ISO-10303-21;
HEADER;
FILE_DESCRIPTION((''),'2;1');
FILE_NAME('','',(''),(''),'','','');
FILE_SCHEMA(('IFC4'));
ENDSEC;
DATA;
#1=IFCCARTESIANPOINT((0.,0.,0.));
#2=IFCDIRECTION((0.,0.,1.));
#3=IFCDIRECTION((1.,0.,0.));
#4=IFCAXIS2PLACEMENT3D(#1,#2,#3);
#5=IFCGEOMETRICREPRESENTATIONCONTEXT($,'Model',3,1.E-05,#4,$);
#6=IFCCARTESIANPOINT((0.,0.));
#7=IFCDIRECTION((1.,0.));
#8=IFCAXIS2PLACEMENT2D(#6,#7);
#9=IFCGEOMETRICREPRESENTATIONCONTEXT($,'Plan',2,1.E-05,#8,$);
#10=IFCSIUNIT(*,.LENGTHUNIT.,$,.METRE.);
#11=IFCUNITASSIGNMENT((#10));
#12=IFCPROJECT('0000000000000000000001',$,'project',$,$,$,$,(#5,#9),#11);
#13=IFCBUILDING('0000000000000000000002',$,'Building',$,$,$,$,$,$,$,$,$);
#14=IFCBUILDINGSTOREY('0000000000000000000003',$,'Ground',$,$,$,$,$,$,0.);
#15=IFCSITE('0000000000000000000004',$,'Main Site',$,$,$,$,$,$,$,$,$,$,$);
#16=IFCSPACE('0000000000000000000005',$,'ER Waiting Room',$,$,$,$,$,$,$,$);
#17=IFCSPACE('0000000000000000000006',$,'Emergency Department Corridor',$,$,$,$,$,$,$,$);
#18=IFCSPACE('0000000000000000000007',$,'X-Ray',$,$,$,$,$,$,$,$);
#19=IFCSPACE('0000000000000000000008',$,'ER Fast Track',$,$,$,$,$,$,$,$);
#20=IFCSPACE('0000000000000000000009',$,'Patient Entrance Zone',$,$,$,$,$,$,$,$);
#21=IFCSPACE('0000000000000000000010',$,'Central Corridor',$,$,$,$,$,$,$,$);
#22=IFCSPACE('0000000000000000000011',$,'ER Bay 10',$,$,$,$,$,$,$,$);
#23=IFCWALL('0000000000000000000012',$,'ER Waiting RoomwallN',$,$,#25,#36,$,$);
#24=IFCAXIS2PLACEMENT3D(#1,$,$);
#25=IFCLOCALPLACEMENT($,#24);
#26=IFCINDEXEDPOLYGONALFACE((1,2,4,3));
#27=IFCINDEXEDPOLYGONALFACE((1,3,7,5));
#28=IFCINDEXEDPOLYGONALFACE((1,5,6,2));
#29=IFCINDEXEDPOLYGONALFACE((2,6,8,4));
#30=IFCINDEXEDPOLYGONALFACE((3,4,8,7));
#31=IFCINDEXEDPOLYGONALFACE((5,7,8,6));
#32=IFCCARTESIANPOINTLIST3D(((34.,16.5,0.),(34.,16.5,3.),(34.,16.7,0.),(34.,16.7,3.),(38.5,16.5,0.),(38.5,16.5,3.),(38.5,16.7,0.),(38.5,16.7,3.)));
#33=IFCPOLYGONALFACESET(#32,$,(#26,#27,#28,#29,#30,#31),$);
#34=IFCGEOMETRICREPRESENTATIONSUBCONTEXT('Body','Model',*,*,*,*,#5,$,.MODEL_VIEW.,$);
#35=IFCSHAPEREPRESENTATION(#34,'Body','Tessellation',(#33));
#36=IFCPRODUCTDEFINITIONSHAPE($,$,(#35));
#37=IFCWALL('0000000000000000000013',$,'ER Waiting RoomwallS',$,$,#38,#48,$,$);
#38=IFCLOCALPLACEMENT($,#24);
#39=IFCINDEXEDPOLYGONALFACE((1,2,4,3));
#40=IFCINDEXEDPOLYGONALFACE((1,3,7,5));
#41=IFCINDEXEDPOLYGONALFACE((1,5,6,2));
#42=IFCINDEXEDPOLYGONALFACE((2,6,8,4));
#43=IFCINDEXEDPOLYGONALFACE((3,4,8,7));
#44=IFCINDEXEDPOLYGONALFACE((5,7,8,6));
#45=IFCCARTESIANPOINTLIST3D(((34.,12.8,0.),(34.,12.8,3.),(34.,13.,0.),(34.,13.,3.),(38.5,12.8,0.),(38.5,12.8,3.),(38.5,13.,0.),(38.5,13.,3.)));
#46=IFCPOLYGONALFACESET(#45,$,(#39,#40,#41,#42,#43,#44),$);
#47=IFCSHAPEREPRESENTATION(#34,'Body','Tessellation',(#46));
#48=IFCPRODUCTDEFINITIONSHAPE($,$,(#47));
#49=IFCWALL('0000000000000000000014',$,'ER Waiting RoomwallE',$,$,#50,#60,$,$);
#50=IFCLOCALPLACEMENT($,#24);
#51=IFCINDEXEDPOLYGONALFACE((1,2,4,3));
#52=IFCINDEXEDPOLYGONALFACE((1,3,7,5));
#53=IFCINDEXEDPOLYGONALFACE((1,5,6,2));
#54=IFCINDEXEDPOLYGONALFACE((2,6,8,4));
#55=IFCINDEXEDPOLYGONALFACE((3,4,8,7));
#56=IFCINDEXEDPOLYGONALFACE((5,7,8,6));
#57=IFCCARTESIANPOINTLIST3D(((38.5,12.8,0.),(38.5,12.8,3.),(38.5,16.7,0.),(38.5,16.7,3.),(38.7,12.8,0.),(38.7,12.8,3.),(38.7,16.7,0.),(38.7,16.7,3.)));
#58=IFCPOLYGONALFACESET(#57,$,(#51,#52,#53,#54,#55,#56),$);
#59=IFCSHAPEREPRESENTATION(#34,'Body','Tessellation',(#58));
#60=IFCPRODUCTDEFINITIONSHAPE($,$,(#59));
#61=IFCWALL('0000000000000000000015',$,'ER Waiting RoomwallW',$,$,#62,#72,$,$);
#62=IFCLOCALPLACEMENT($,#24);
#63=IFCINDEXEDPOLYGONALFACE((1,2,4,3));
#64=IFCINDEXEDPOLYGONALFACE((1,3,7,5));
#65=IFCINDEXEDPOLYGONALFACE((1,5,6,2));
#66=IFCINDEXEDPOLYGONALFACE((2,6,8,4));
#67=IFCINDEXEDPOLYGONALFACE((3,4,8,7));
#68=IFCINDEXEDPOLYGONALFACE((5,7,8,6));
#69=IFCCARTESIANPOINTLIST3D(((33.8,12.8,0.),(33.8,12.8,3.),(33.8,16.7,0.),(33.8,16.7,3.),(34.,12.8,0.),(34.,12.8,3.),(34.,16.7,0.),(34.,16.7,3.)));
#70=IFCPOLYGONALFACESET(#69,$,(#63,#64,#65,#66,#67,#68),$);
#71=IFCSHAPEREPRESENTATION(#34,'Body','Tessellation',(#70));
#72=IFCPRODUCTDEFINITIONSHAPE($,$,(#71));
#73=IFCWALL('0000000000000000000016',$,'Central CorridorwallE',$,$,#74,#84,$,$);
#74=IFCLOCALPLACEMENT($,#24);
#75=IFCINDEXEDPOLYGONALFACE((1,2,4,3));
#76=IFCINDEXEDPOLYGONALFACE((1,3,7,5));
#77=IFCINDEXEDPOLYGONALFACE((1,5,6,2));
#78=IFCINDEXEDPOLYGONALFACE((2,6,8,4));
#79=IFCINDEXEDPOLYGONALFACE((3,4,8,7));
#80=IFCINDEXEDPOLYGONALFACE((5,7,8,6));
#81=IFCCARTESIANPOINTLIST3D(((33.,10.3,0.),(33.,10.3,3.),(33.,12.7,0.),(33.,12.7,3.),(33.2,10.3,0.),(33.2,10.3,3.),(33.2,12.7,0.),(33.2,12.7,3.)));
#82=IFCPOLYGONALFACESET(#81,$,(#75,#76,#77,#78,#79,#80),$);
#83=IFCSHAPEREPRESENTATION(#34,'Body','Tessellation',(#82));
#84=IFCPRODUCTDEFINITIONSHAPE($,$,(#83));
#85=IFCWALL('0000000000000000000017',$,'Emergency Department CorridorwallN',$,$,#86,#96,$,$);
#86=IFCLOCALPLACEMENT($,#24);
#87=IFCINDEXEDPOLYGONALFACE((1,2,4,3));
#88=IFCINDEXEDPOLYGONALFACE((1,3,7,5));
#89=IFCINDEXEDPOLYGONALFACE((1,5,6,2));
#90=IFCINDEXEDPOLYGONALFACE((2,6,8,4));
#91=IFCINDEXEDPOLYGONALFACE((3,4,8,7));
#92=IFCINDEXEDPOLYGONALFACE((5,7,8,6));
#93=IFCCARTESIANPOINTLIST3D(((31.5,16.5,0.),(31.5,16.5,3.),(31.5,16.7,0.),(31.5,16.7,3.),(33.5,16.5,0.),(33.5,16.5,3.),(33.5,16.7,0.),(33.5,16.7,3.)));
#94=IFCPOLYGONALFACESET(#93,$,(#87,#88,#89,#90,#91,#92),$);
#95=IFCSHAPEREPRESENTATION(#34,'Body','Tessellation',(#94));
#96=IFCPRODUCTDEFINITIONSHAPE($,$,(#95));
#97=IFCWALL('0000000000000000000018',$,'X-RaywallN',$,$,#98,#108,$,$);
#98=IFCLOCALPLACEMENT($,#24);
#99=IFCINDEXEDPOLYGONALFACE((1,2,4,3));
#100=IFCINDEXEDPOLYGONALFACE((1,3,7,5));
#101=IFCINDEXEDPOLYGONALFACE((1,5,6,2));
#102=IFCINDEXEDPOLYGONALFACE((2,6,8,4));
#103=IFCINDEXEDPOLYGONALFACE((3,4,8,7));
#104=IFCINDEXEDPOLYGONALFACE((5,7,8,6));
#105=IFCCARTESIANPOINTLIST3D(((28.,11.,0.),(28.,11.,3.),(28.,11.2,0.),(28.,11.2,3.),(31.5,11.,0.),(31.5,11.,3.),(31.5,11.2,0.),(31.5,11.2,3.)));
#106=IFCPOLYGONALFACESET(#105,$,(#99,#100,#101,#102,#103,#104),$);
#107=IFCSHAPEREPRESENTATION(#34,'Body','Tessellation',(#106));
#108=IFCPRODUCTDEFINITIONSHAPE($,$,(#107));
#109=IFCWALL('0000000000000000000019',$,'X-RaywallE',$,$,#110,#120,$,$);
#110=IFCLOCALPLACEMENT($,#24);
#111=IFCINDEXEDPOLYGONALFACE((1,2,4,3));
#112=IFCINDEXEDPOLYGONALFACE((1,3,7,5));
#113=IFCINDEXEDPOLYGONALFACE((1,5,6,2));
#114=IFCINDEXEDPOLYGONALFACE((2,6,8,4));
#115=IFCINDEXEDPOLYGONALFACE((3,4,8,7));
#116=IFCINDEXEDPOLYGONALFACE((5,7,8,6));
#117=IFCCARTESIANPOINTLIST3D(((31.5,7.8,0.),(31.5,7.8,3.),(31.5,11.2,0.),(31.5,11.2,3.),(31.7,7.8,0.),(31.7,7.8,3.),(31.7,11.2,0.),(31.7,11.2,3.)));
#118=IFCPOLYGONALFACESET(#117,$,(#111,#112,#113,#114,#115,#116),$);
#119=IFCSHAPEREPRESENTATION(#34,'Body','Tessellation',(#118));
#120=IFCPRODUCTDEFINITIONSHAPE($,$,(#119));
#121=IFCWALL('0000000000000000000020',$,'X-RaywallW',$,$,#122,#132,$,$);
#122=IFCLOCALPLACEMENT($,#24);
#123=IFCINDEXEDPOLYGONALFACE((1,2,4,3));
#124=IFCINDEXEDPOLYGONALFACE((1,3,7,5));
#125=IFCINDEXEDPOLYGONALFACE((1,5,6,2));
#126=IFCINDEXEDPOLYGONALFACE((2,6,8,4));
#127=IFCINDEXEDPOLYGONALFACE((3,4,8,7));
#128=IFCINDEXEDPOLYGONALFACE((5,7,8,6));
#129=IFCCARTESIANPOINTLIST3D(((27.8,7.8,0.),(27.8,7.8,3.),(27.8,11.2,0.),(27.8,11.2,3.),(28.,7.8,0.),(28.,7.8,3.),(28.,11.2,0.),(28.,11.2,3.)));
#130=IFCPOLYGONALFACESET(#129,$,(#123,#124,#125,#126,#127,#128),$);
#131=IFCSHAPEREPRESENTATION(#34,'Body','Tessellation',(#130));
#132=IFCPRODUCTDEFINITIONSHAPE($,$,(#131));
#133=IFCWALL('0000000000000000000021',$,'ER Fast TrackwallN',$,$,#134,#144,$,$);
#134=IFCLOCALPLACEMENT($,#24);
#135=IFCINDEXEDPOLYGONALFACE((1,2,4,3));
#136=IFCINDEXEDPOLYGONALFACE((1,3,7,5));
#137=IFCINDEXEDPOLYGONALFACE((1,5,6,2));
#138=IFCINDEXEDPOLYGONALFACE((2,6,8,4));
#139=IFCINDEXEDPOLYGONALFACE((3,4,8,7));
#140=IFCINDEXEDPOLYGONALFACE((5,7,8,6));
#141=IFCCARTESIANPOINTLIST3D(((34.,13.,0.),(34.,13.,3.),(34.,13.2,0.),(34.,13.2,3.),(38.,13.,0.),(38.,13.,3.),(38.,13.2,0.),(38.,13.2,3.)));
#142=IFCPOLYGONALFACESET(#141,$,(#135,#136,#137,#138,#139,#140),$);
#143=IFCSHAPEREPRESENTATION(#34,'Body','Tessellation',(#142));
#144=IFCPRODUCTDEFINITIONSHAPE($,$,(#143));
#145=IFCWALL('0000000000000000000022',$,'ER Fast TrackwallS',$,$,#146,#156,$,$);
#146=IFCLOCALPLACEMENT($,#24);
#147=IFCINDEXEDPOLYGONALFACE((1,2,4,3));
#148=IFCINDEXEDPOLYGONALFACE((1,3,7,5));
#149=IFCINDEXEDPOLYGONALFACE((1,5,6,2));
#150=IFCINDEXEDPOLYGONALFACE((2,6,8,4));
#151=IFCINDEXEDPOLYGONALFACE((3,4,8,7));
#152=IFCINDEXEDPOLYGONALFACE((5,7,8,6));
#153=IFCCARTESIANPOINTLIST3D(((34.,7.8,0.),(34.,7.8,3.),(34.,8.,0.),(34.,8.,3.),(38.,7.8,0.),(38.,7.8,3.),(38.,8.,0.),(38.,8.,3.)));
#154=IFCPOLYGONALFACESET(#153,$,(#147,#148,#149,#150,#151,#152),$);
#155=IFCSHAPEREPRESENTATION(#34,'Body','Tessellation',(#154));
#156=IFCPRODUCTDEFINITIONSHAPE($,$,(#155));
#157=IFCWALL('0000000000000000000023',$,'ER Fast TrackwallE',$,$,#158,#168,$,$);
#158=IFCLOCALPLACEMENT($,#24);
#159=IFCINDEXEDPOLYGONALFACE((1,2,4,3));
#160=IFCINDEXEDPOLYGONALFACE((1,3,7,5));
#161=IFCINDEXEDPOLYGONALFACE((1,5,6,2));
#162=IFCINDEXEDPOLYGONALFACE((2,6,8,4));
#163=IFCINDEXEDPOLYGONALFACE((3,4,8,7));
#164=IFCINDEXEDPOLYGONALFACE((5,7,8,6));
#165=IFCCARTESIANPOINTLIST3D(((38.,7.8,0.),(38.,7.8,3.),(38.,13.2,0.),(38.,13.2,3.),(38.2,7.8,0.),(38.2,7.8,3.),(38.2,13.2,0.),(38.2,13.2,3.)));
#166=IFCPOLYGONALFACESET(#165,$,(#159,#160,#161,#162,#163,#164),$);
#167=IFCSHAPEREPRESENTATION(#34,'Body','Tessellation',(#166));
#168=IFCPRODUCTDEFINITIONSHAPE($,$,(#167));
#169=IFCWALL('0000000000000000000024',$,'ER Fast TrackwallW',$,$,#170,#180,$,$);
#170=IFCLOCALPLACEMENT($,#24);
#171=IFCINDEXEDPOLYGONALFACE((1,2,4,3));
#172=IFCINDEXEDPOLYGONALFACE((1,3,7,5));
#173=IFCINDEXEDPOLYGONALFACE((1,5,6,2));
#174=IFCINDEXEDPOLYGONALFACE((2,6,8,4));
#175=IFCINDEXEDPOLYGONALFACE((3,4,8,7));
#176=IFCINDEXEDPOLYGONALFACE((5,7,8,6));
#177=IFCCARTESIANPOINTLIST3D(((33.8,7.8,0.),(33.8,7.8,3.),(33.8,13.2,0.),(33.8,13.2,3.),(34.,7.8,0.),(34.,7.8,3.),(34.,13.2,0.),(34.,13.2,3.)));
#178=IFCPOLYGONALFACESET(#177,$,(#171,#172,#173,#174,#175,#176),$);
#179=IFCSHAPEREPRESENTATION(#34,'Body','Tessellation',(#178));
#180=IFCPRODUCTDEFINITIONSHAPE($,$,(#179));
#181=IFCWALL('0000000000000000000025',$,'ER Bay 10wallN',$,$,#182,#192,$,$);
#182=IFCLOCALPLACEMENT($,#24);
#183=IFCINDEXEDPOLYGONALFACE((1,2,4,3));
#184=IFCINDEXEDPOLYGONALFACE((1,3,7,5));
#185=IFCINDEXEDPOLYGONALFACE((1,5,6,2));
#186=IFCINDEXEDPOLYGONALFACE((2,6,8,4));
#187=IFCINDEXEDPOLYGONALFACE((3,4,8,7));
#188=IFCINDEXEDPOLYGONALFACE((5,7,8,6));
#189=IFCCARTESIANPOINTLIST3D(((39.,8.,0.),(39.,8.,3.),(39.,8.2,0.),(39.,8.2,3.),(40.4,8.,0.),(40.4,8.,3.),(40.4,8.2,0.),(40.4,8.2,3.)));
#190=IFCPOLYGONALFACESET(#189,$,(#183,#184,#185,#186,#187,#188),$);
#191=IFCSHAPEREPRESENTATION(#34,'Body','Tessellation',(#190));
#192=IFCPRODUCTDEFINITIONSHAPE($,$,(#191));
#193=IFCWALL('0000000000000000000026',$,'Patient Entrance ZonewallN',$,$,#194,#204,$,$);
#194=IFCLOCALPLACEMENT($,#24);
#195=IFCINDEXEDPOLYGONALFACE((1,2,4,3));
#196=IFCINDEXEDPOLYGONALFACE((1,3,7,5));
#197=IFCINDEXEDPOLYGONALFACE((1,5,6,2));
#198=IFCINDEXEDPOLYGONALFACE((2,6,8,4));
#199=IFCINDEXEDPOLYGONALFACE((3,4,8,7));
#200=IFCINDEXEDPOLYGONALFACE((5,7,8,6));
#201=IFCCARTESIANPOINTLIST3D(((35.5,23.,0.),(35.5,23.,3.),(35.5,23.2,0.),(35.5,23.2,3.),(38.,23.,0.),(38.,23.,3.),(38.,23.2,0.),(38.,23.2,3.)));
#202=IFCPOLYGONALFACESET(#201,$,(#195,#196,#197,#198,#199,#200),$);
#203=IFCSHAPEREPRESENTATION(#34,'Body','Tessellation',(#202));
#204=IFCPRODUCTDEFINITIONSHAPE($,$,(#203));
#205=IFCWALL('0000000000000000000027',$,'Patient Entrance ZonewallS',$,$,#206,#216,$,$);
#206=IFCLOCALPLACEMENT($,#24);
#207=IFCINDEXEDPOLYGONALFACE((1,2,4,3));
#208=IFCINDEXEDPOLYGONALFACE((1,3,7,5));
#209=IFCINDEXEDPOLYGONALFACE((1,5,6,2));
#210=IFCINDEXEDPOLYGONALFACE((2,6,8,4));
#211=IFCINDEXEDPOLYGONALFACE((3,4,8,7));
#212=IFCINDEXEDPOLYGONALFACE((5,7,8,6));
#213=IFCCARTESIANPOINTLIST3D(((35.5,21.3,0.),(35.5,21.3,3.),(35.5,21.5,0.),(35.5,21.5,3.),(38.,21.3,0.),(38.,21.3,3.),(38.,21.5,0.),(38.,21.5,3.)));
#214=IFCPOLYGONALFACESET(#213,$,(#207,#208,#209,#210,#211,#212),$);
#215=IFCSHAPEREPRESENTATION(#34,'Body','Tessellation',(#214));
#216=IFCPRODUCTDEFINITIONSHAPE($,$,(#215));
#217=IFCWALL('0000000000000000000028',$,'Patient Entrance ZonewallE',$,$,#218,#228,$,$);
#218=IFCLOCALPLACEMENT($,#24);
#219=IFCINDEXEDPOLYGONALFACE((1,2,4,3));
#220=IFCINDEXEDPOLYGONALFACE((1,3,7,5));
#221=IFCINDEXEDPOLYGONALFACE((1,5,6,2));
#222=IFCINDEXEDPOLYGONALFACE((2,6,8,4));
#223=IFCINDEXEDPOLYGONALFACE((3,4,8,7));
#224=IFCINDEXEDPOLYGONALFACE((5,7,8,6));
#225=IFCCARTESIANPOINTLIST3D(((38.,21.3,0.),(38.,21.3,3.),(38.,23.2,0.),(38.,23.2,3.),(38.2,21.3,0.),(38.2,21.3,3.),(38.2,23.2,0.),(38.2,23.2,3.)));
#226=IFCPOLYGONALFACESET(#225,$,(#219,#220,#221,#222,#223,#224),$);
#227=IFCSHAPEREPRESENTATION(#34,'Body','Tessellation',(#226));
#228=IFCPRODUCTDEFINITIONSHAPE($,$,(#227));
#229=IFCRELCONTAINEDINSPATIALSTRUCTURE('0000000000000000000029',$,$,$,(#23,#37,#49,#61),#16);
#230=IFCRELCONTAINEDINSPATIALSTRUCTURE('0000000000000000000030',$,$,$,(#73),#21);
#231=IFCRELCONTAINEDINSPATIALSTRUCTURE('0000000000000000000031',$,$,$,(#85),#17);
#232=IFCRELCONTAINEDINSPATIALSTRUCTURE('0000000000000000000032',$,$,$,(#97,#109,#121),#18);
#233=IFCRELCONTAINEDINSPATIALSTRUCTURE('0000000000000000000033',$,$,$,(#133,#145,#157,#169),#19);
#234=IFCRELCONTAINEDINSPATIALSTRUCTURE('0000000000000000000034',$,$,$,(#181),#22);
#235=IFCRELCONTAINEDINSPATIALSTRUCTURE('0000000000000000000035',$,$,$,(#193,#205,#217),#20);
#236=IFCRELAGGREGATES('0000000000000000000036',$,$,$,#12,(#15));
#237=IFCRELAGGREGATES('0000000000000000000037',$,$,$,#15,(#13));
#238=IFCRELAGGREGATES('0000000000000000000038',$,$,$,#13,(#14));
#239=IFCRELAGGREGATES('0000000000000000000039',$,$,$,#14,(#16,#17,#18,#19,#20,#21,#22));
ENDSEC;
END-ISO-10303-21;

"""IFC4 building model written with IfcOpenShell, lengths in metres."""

from ifc_helpers import new_model, si_unit, frame, origin_with_axes, origin_2d_with_axis, place, context, subcontext, project, spatial, indexed_curve, outline, extrude, element, save


model = new_model("IFC4")

# Units and contexts
model_context = context("Model", 3, precision=1e-05, world=origin_with_axes())
plan_context = context("Plan", 2, precision=1e-05, world=origin_2d_with_axis())
body_context = subcontext(model_context, "Body", "Model", "MODEL_VIEW")
ifc_project = project(units=[si_unit("LENGTHUNIT", "METRE")], contexts=[model_context, plan_context])

# Site, building, storey
site = spatial("IfcSite", under=ifc_project, Name="Main Site")
building = spatial("IfcBuilding", under=site, Name="Building")
storey = spatial("IfcBuildingStorey", under=building, Name="Ground", Elevation=0.0)

# Shared definitions
space_1 = spatial("IfcSpace", under=storey, Name="ER Waiting Room")

# Shared definitions
space_2 = spatial("IfcSpace", under=storey, Name="Emergency Department Corridor")

# Shared definitions
space_3 = spatial("IfcSpace", under=storey, Name="X-Ray")

# Shared definitions
space_4 = spatial("IfcSpace", under=storey, Name="ER Fast Track")

# Shared definitions
space_5 = spatial("IfcSpace", under=storey, Name="Patient Entrance Zone")

# Walls
for number, where, z_axis, x_axis, name in (
    (1, (34.0, 16.5, 0.0), (0.0, 0.0, 1.0), (1.0, 0.0, 0.0), "ER Waiting RoomwallN"),
    (2, (34.0, 12.8, 0.0), (0.0, 0.0, 1.0), (1.0, 0.0, 0.0), "ER Waiting RoomwallS"),
):
    element("IfcWall", number, at=place(None, frame(where, z_axis=z_axis, x_axis=x_axis)), inside=space_1, Name=name, context=body_context, shape_type="SweptSolid", body=[
        extrude(outline(indexed_curve([(0.0, 0.0), (0.0, 0.2), (4.5, 0.2), (4.5, 0.0), (0.0, 0.0)], self_intersect=False)), origin_with_axes(), (0.0, 0.0, 1.0), 3.0),
    ])
for number, where, z_axis, x_axis, name in (
    (3, (38.7, 12.8, 0.0), (0.0, 0.0, 1.0), (0.0, 1.0, 0.0), "ER Waiting RoomwallE"),
    (4, (34.0, 12.8, 0.0), (0.0, 0.0, 1.0), (0.0, 1.0, 0.0), "ER Waiting RoomwallW"),
):
    element("IfcWall", number, at=place(None, frame(where, z_axis=z_axis, x_axis=x_axis)), inside=space_1, Name=name, context=body_context, shape_type="SweptSolid", body=[
        extrude(outline(indexed_curve([(0.0, 0.0), (0.0, 0.2), (3.9, 0.2), (3.9, 0.0), (0.0, 0.0)], self_intersect=False)), origin_with_axes(), (0.0, 0.0, 1.0), 3.0),
    ])

# Shared definitions
space_6 = spatial("IfcSpace", under=storey, Name="Central Corridor")

# Walls
wall_1_placement = place(None, frame((33.2, 10.3, 0.0), z_axis=(0.0, 0.0, 1.0), x_axis=(0.0, 1.0, 0.0)))
element("IfcWall", 5, at=wall_1_placement, inside=space_6, Name="Central CorridorwallE", context=body_context, shape_type="SweptSolid", body=[
    extrude(outline(indexed_curve([(0.0, 0.0), (0.0, 0.2), (2.4, 0.2), (2.4, 0.0), (0.0, 0.0)], self_intersect=False)), origin_with_axes(), (0.0, 0.0, 1.0), 3.0),
])
wall_2_placement = place(None, frame((31.5, 16.5, 0.0), z_axis=(0.0, 0.0, 1.0), x_axis=(1.0, 0.0, 0.0)))
element("IfcWall", 6, at=wall_2_placement, inside=space_2, Name="Emergency Department CorridorwallN", context=body_context, shape_type="SweptSolid", body=[
    extrude(outline(indexed_curve([(0.0, 0.0), (0.0, 0.2), (2.0, 0.2), (2.0, 0.0), (0.0, 0.0)], self_intersect=False)), origin_with_axes(), (0.0, 0.0, 1.0), 3.0),
])
wall_3_placement = place(None, frame((28.0, 11.0, 0.0), z_axis=(0.0, 0.0, 1.0), x_axis=(1.0, 0.0, 0.0)))
element("IfcWall", 7, at=wall_3_placement, inside=space_3, Name="X-RaywallN", context=body_context, shape_type="SweptSolid", body=[
    extrude(outline(indexed_curve([(0.0, 0.0), (0.0, 0.2), (3.5, 0.2), (3.5, 0.0), (0.0, 0.0)], self_intersect=False)), origin_with_axes(), (0.0, 0.0, 1.0), 3.0),
])
for number, where, z_axis, x_axis, name in (
    (8, (31.7, 7.8, 0.0), (0.0, 0.0, 1.0), (0.0, 1.0, 0.0), "X-RaywallE"),
    (9, (28.0, 7.8, 0.0), (0.0, 0.0, 1.0), (0.0, 1.0, 0.0), "X-RaywallW"),
):
    element("IfcWall", number, at=place(None, frame(where, z_axis=z_axis, x_axis=x_axis)), inside=space_3, Name=name, context=body_context, shape_type="SweptSolid", body=[
        extrude(outline(indexed_curve([(0.0, 0.0), (0.0, 0.2), (3.4, 0.2), (3.4, 0.0), (0.0, 0.0)], self_intersect=False)), origin_with_axes(), (0.0, 0.0, 1.0), 3.0),
    ])
for number, where, z_axis, x_axis, name in (
    (10, (34.0, 13.0, 0.0), (0.0, 0.0, 1.0), (1.0, 0.0, 0.0), "ER Fast TrackwallN"),
    (11, (34.0, 7.8, 0.0), (0.0, 0.0, 1.0), (1.0, 0.0, 0.0), "ER Fast TrackwallS"),
):
    element("IfcWall", number, at=place(None, frame(where, z_axis=z_axis, x_axis=x_axis)), inside=space_4, Name=name, context=body_context, shape_type="SweptSolid", body=[
        extrude(outline(indexed_curve([(0.0, 0.0), (0.0, 0.2), (4.0, 0.2), (4.0, 0.0), (0.0, 0.0)], self_intersect=False)), origin_with_axes(), (0.0, 0.0, 1.0), 3.0),
    ])
for number, where, z_axis, x_axis, name in (
    (12, (38.2, 7.8, 0.0), (0.0, 0.0, 1.0), (0.0, 1.0, 0.0), "ER Fast TrackwallE"),
    (13, (34.0, 7.8, 0.0), (0.0, 0.0, 1.0), (0.0, 1.0, 0.0), "ER Fast TrackwallW"),
):
    element("IfcWall", number, at=place(None, frame(where, z_axis=z_axis, x_axis=x_axis)), inside=space_4, Name=name, context=body_context, shape_type="SweptSolid", body=[
        extrude(outline(indexed_curve([(0.0, 0.0), (0.0, 0.2), (5.4, 0.2), (5.4, 0.0), (0.0, 0.0)], self_intersect=False)), origin_with_axes(), (0.0, 0.0, 1.0), 3.0),
    ])

# Shared definitions
space_7 = spatial("IfcSpace", under=storey, Name="ER Bay 10")

# Walls
wall_4_placement = place(None, frame((39.0, 8.0, 0.0), z_axis=(0.0, 0.0, 1.0), x_axis=(1.0, 0.0, 0.0)))
element("IfcWall", 14, at=wall_4_placement, inside=space_7, Name="ER Bay 10wallN", context=body_context, shape_type="SweptSolid", body=[
    extrude(outline(indexed_curve([(0.0, 0.0), (0.0, 0.2), (1.4, 0.2), (1.4, 0.0), (0.0, 0.0)], self_intersect=False)), origin_with_axes(), (0.0, 0.0, 1.0), 3.0),
])
for number, where, z_axis, x_axis, name in (
    (15, (35.5, 23.0, 0.0), (0.0, 0.0, 1.0), (1.0, 0.0, 0.0), "Patient Entrance ZonewallN"),
    (16, (35.5, 21.3, 0.0), (0.0, 0.0, 1.0), (1.0, 0.0, 0.0), "Patient Entrance ZonewallS"),
):
    element("IfcWall", number, at=place(None, frame(where, z_axis=z_axis, x_axis=x_axis)), inside=space_5, Name=name, context=body_context, shape_type="SweptSolid", body=[
        extrude(outline(indexed_curve([(0.0, 0.0), (0.0, 0.2), (2.5, 0.2), (2.5, 0.0), (0.0, 0.0)], self_intersect=False)), origin_with_axes(), (0.0, 0.0, 1.0), 3.0),
    ])
for number, where, z_axis, x_axis, name in (
    (17, (38.2, 21.3, 0.0), (0.0, 0.0, 1.0), (0.0, 1.0, 0.0), "Patient Entrance ZonewallE"),
):
    element("IfcWall", number, at=place(None, frame(where, z_axis=z_axis, x_axis=x_axis)), inside=space_5, Name=name, context=body_context, shape_type="SweptSolid", body=[
        extrude(outline(indexed_curve([(0.0, 0.0), (0.0, 0.2), (1.9, 0.2), (1.9, 0.0), (0.0, 0.0)], self_intersect=False)), origin_with_axes(), (0.0, 0.0, 1.0), 3.0),
    ])

save(model, "model.ifc")
